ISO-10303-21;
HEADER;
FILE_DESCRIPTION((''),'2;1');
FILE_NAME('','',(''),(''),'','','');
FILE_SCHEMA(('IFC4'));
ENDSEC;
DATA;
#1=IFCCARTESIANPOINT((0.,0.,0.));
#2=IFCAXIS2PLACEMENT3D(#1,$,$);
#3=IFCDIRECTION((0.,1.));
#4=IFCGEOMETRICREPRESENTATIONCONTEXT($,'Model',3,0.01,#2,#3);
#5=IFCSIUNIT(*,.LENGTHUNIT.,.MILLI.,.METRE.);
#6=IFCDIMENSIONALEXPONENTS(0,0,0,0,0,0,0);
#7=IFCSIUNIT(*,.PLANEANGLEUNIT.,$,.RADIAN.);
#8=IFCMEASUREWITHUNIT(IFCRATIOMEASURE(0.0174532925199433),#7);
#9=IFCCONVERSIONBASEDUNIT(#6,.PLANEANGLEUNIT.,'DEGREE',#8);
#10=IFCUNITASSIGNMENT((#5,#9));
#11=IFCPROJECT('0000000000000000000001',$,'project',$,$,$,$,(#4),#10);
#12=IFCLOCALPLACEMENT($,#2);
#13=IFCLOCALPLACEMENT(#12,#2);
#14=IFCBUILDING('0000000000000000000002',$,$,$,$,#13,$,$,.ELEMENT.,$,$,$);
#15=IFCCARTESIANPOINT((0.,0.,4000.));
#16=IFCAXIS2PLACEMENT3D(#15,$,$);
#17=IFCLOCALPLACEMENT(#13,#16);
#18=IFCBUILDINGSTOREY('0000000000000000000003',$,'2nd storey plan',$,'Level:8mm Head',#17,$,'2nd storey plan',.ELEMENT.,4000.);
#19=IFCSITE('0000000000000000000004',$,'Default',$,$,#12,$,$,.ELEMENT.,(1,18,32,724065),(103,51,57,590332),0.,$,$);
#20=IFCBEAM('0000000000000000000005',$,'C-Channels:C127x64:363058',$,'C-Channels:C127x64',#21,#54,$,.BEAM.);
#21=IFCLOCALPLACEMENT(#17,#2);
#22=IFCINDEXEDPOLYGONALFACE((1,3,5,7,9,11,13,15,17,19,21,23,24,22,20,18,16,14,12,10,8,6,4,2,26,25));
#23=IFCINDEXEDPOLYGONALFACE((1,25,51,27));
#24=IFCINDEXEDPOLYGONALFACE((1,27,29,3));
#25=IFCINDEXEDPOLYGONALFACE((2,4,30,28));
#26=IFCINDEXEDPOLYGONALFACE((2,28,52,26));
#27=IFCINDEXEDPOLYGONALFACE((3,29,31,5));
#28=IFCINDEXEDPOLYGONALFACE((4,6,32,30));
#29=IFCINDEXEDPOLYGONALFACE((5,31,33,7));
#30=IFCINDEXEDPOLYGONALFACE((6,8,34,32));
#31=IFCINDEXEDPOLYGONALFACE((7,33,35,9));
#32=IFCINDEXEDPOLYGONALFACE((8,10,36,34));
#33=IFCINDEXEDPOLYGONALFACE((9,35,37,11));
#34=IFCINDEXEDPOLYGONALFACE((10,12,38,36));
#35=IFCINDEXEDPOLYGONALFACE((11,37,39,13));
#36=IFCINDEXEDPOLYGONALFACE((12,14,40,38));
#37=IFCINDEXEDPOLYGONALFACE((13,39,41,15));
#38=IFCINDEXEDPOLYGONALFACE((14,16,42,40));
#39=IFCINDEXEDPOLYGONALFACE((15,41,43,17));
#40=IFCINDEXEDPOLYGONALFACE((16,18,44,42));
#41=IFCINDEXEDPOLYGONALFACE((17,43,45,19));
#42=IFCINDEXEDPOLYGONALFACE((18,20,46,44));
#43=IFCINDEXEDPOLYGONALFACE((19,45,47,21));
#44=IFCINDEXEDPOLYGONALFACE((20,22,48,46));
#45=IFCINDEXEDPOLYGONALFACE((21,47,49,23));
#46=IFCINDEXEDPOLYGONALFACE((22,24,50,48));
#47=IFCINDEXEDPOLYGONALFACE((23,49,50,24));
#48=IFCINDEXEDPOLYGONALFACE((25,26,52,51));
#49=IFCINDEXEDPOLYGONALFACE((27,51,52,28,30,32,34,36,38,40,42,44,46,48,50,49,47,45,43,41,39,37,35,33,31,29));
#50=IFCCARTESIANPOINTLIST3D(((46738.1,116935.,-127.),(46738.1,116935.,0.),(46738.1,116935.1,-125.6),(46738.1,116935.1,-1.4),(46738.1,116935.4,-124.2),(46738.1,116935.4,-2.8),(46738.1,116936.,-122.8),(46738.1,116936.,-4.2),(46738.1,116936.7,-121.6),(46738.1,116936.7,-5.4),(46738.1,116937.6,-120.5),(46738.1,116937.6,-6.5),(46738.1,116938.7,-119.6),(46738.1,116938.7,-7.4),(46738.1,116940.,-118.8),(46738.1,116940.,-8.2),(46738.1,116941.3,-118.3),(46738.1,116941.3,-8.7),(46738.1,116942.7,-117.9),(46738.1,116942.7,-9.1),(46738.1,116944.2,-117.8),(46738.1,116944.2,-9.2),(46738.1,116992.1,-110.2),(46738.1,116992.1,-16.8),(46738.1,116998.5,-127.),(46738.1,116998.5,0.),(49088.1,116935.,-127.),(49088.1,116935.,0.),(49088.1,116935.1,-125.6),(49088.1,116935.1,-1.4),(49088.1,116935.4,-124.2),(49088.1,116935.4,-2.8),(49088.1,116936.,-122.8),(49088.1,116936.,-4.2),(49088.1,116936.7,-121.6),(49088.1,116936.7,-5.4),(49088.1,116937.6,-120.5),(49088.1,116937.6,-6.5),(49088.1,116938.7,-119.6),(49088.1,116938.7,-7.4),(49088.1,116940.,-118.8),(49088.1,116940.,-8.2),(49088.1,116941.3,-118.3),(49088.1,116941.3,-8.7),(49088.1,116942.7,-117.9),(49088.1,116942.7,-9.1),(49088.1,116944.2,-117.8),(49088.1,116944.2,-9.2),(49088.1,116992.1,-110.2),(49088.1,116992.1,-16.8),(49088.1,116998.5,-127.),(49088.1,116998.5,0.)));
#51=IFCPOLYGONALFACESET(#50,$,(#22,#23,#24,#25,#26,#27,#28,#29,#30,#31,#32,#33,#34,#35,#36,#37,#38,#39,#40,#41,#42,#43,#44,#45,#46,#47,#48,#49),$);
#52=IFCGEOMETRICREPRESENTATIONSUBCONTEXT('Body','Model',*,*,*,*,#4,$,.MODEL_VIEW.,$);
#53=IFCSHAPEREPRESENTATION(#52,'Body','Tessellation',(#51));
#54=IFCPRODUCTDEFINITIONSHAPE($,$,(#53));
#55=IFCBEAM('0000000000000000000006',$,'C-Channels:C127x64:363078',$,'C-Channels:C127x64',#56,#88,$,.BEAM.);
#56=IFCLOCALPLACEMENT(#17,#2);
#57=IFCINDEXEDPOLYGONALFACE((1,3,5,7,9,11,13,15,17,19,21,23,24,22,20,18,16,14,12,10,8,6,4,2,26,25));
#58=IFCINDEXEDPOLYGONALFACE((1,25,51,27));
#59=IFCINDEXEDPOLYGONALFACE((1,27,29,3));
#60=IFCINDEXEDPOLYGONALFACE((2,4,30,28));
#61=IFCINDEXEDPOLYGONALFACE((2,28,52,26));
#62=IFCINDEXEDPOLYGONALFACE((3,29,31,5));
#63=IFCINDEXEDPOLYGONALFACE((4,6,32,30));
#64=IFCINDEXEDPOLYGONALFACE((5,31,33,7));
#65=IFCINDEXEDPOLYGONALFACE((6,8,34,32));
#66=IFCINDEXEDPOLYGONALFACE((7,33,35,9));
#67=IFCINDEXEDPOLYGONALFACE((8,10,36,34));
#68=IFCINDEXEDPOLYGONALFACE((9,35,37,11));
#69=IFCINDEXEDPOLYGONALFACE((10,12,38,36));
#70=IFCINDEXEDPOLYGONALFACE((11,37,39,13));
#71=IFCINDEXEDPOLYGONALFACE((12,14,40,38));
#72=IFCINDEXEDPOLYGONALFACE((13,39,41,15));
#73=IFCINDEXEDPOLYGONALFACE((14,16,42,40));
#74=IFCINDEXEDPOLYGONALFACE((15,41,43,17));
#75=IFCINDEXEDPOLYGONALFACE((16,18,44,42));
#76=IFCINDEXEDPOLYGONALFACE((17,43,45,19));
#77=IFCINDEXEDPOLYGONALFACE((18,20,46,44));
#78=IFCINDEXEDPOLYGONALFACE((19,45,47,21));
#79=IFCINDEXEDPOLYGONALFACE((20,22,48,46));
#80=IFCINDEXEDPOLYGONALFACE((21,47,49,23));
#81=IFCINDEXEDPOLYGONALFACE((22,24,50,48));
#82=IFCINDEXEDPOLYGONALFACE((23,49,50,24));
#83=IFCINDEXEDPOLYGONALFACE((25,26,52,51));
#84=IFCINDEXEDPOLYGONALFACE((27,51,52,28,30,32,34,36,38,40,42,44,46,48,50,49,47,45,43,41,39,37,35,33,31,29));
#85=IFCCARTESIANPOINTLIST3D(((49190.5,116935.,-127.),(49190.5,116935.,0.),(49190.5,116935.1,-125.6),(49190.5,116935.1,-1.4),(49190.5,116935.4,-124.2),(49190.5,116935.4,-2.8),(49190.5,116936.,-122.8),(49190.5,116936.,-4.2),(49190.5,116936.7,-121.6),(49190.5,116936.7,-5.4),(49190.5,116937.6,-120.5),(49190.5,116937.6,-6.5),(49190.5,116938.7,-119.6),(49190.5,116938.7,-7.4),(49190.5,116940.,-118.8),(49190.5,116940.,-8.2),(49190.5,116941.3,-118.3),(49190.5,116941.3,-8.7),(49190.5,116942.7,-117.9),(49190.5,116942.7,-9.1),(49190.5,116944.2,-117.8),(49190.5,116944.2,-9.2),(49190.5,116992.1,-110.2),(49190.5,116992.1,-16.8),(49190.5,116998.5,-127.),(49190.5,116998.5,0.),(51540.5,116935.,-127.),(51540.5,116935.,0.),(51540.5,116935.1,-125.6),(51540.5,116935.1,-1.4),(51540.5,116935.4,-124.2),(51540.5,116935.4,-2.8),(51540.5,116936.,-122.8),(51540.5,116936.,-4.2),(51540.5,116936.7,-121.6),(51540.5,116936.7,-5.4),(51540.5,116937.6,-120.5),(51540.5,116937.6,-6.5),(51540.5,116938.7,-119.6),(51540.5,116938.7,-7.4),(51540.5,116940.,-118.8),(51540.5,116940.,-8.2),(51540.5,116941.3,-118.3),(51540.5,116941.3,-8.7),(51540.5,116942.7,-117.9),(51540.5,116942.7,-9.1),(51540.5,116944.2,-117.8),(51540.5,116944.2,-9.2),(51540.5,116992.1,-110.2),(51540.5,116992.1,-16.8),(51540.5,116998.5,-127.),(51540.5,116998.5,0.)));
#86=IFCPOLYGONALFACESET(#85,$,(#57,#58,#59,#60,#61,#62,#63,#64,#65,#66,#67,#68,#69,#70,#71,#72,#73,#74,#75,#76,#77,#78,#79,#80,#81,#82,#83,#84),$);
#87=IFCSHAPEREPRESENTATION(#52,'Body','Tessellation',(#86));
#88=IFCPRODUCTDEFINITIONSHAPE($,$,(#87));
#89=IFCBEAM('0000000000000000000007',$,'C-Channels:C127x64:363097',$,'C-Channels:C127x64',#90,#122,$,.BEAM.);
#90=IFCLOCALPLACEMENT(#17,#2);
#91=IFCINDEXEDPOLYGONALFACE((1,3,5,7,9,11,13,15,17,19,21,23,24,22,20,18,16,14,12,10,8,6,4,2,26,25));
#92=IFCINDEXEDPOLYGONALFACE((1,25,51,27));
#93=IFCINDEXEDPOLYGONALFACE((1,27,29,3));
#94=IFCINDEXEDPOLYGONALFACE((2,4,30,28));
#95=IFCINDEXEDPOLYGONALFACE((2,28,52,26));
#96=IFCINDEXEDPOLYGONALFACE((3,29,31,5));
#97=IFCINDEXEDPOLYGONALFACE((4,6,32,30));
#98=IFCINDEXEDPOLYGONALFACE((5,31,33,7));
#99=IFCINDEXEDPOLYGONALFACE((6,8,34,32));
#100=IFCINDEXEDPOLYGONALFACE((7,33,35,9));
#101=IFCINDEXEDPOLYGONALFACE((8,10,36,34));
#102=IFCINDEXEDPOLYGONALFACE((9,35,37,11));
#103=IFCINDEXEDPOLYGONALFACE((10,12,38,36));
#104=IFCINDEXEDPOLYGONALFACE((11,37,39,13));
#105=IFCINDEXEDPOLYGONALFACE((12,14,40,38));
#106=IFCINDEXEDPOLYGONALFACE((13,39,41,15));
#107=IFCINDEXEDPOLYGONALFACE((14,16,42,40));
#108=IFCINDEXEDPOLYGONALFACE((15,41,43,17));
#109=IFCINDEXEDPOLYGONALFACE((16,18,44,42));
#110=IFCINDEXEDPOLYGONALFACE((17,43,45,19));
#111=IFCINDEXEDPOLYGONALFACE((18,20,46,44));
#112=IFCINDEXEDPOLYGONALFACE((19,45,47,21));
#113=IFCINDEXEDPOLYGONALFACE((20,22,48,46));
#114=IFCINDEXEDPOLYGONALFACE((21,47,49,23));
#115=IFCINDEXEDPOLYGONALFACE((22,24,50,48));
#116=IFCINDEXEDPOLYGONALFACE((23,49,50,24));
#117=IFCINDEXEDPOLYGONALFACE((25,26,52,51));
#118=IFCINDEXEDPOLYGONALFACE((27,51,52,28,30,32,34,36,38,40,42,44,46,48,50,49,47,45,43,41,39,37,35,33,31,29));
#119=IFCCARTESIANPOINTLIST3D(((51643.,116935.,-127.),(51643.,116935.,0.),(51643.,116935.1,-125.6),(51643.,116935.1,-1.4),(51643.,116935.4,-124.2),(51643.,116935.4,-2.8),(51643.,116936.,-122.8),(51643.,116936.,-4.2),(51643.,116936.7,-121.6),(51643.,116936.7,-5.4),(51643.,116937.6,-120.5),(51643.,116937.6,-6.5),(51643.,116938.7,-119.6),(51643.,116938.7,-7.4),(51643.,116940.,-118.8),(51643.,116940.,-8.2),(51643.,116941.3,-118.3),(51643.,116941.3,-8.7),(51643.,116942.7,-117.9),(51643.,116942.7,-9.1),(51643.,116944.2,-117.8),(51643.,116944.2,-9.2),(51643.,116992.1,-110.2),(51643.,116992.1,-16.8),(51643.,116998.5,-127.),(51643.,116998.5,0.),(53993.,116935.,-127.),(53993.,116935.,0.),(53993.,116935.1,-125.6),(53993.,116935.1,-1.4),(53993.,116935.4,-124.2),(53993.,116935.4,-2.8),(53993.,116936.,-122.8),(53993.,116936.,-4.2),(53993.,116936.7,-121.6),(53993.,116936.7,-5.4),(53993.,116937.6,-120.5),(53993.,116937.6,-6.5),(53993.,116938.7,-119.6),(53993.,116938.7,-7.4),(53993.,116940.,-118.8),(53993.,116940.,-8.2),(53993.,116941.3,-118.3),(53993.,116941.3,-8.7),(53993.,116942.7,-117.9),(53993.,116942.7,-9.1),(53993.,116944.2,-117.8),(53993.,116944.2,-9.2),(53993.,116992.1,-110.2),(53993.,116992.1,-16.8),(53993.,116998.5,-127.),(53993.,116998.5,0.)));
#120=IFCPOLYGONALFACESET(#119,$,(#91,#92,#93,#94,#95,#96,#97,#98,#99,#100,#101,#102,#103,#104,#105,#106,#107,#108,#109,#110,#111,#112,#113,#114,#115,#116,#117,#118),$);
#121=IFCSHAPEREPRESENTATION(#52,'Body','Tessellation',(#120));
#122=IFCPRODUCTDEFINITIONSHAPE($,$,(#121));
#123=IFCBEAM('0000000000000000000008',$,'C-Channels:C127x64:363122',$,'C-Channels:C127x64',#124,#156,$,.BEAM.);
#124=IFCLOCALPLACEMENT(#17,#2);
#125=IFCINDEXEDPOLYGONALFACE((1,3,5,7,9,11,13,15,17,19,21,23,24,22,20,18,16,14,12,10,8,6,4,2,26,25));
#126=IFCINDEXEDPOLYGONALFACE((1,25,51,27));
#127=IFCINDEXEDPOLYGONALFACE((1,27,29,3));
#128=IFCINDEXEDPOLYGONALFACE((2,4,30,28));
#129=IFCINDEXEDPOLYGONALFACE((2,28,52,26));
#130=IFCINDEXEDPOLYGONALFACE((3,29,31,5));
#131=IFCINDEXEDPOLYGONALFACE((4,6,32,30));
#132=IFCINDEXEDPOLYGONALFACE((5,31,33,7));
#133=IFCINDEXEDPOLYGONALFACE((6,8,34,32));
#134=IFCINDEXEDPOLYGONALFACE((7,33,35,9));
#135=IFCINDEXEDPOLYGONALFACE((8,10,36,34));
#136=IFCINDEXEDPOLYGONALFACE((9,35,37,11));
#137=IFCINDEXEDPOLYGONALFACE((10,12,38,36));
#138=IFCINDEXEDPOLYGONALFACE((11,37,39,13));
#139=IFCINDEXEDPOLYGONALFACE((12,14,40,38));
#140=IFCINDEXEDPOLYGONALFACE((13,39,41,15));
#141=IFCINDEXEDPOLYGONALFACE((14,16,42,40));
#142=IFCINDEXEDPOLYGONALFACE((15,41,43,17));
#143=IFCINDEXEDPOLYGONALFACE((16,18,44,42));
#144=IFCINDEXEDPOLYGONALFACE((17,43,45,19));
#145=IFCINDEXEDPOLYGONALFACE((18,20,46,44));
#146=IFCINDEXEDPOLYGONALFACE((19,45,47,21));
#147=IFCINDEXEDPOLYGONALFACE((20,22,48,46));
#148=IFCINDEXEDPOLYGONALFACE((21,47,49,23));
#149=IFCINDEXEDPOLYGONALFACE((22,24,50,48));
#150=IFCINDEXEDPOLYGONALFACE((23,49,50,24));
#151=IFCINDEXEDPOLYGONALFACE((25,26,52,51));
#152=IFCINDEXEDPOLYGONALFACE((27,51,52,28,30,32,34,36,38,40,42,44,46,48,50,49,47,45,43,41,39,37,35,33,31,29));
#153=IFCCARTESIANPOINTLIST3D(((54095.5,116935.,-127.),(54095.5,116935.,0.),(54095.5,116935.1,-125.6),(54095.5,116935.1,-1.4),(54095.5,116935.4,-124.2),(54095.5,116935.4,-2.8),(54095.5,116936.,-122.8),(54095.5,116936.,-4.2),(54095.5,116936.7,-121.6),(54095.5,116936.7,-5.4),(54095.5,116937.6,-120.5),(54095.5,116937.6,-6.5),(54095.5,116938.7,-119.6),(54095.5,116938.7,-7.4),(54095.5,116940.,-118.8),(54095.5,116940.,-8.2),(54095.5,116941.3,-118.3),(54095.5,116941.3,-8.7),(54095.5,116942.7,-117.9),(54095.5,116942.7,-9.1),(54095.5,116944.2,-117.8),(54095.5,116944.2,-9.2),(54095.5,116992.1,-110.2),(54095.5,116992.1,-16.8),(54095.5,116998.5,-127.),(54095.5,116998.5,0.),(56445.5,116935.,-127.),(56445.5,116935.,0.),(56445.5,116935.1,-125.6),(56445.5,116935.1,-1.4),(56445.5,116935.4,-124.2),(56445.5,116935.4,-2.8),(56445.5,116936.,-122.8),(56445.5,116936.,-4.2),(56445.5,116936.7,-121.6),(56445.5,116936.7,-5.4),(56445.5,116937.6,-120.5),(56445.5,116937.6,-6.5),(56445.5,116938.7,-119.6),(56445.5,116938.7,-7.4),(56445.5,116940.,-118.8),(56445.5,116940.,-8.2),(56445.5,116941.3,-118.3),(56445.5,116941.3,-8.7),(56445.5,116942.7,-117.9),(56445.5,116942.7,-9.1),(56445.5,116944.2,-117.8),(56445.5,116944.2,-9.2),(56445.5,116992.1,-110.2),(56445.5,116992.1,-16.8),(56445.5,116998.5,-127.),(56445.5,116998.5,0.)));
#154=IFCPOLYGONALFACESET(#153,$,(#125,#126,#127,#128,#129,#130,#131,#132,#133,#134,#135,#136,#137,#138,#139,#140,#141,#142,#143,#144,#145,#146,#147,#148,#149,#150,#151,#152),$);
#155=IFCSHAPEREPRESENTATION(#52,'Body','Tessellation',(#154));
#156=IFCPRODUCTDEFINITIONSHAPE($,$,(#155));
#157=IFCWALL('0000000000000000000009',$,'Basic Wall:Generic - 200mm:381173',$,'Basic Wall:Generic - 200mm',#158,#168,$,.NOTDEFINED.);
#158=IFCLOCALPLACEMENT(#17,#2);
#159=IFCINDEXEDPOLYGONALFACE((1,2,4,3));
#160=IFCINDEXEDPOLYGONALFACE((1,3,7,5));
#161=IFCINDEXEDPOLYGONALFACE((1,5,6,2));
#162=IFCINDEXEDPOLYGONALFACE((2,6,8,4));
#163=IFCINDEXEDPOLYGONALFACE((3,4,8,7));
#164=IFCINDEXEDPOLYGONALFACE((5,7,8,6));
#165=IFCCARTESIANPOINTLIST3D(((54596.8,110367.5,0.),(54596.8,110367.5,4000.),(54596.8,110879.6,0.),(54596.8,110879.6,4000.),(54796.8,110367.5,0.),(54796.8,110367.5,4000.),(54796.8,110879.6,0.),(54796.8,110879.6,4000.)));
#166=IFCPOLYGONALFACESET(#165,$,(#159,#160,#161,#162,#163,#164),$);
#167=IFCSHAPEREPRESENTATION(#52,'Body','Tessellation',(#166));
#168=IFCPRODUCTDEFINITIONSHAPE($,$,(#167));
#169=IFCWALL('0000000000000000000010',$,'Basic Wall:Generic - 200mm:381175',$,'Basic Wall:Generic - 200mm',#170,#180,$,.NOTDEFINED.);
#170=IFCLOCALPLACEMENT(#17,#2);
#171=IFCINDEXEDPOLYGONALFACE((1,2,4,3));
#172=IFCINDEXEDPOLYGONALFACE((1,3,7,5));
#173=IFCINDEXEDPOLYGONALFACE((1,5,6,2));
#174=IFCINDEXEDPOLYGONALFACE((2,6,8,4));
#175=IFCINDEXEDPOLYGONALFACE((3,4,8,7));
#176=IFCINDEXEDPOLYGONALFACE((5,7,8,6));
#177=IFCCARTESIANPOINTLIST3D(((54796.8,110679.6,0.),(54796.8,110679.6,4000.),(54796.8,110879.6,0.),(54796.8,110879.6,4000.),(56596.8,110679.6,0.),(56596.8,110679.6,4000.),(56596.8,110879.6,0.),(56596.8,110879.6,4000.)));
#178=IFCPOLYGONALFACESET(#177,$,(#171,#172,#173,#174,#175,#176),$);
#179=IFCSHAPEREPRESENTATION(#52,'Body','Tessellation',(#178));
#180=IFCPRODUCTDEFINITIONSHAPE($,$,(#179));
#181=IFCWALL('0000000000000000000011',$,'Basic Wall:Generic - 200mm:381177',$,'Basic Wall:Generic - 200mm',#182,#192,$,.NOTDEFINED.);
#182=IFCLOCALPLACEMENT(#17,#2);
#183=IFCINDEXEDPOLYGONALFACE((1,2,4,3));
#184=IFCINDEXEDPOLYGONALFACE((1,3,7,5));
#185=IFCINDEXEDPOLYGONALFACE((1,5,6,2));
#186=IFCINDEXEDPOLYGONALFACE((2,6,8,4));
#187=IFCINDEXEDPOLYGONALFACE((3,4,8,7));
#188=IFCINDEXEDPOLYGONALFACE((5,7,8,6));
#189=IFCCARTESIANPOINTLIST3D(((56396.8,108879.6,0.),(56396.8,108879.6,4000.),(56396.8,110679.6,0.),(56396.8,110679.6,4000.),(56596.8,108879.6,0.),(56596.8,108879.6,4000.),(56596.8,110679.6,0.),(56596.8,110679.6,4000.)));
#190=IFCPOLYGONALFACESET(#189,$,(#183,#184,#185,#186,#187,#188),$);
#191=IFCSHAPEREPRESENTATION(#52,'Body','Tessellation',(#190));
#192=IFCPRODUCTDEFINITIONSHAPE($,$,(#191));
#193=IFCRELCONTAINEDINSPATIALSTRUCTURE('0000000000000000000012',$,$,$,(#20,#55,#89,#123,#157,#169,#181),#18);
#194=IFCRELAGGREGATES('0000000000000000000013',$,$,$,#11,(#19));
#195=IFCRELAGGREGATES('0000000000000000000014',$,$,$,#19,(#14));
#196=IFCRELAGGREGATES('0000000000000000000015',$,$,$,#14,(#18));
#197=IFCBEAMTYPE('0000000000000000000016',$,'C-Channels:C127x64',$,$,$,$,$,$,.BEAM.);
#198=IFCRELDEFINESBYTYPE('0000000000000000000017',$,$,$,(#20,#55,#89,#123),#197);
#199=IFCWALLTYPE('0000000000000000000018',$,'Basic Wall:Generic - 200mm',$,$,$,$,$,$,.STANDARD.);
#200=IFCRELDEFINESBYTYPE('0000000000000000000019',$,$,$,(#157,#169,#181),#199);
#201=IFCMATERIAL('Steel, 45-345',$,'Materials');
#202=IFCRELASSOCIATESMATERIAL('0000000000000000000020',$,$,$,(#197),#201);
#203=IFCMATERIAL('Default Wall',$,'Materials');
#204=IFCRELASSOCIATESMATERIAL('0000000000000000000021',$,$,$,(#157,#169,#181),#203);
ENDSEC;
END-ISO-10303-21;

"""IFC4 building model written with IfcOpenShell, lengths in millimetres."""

from ifc_helpers import new_model, entity, si_unit, converted_unit, direction, frame, origin, place, context, subcontext, project, spatial, indexed_curve, outline, extrude, source, transform, mapped, material, type_object, type_shapes, element, save


model = new_model("IFC4")

# Units and contexts
model_context = context("Model", 3, precision=0.01, world=origin(), true_north=direction((0.0, 1.0)))
body_context = subcontext(model_context, "Body", "Model", "MODEL_VIEW")
ifc_project = project(units=[si_unit("LENGTHUNIT", "METRE", prefix="MILLI"), converted_unit("PLANEANGLEUNIT", "DEGREE", entity("IfcRatioMeasure", 0.0174532925199433), si_unit("PLANEANGLEUNIT", "RADIAN"), dimensions=[0, 0, 0, 0, 0, 0, 0])], contexts=[model_context])

# Site, building, storey
site_placement = place(None, origin())
site = spatial("IfcSite", under=ifc_project, at=site_placement, Name="Default", CompositionType="ELEMENT", RefLatitude=(1, 18, 32, 724065), RefLongitude=(103, 51, 57, 590332), RefElevation=0.0)
building_placement = place(site_placement, origin())
building = spatial("IfcBuilding", under=site, at=building_placement, CompositionType="ELEMENT")
storey_placement = place(building_placement, frame((0.0, 0.0, 4000.0)))
storey = spatial("IfcBuildingStorey", under=building, at=storey_placement, Name="2nd storey plan", ObjectType="Level:8mm Head", LongName="2nd storey plan", CompositionType="ELEMENT", Elevation=4000.0)

# Beams
ifc_material_1 = material(Name="Steel, 45-345", Category="Materials")
beam_type_1 = type_object("IfcBeamType", Name="C-Channels:C127x64", PredefinedType="BEAM", material=ifc_material_1)
shared_shape_1 = source(origin(), body_context, "Body", "SweptSolid", [
    extrude(outline(indexed_curve([(-32.5, -63.5), (31.0, -63.5), (31.0, 63.5), (-32.4, 63.5), (-32.3, 62.1), (-32.0, 60.7), (-31.4, 59.3), (-30.7, 58.1), (-29.8, 57.0), (-28.7, 56.1), (-27.4, 55.3), (-26.1, 54.8), (-24.7, 54.4), (-23.2, 54.3), (24.6, 46.7), (24.6, -46.7), (-23.2, -54.3), (-24.7, -54.4), (-26.1, -54.8), (-27.4, -55.3), (-28.7, -56.1), (-29.8, -57.0), (-30.7, -58.1), (-31.4, -59.3), (-32.0, -60.7), (-32.3, -62.1), (-32.5, -63.5)], self_intersect=False)), frame((-1175.0, -11.7, 0.0), z_axis=(1.0, 0.0, 0.0), x_axis=(0.0, 1.0, 0.0)), (0.0, 0.0, 1.0), 2350.0),
])
type_shapes(beam_type_1, [shared_shape_1])
for number, where, name in (
    (1, (47913.1, 116979.1, -63.5), "C-Channels:C127x64:363058"),
    (2, (50365.5, 116979.1, -63.5), "C-Channels:C127x64:363078"),
    (3, (52818.0, 116979.1, -63.5), "C-Channels:C127x64:363097"),
    (4, (55270.5, 116979.1, -63.5), "C-Channels:C127x64:363122"),
):
    element("IfcBeam", number, at=place(storey_placement, frame(where)), inside=storey, type_object=beam_type_1, Name=name, ObjectType="C-Channels:C127x64", PredefinedType="BEAM", context=body_context, shape_type="MappedRepresentation", body=[
        mapped(shared_shape_1, transform((0.0, 0.0, 0.0), scale=1.0)),
    ])

# Walls
ifc_material_2 = material(Name="Default Wall", Category="Materials")
wall_type = type_object("IfcWallType", Name="Basic Wall:Generic - 200mm", PredefinedType="STANDARD")
wall_1_placement = place(storey_placement, frame((54696.8, 110367.5, 0.0), z_axis=(0.0, 0.0, 1.0), x_axis=(0.0, 1.0, 0.0)))
element("IfcWall", 5, at=wall_1_placement, inside=storey, type_object=wall_type, material=ifc_material_2, Name="Basic Wall:Generic - 200mm:381173", ObjectType="Basic Wall:Generic - 200mm", PredefinedType="NOTDEFINED", context=body_context, shape_type="SweptSolid", body=[
    extrude(outline(indexed_curve([(512.1, 100.0), (0.0, 100.0), (0.0, -100.0), (512.1, -100.0), (512.1, 100.0)], self_intersect=False)), origin(), (0.0, 0.0, 1.0), 4000.0),
])
wall_2_placement = place(storey_placement, frame((54796.8, 110779.6, 0.0)))
element("IfcWall", 6, at=wall_2_placement, inside=storey, type_object=wall_type, material=ifc_material_2, Name="Basic Wall:Generic - 200mm:381175", ObjectType="Basic Wall:Generic - 200mm", PredefinedType="NOTDEFINED", context=body_context, shape_type="SweptSolid", body=[
    extrude(outline(indexed_curve([(1800.0, 100.0), (0.0, 100.0), (0.0, -100.0), (1800.0, -100.0), (1800.0, 100.0)], self_intersect=False)), origin(), (0.0, 0.0, 1.0), 4000.0),
])
wall_3_placement = place(storey_placement, frame((56496.8, 110679.6, 0.0), z_axis=(0.0, 0.0, 1.0), x_axis=(0.0, -1.0, 0.0)))
element("IfcWall", 7, at=wall_3_placement, inside=storey, type_object=wall_type, material=ifc_material_2, Name="Basic Wall:Generic - 200mm:381177", ObjectType="Basic Wall:Generic - 200mm", PredefinedType="NOTDEFINED", context=body_context, shape_type="SweptSolid", body=[
    extrude(outline(indexed_curve([(1800.0, 100.0), (0.0, 100.0), (0.0, -100.0), (1800.0, -100.0), (1800.0, 100.0)], self_intersect=False)), origin(), (0.0, 0.0, 1.0), 4000.0),
])

save(model, "model.ifc")
